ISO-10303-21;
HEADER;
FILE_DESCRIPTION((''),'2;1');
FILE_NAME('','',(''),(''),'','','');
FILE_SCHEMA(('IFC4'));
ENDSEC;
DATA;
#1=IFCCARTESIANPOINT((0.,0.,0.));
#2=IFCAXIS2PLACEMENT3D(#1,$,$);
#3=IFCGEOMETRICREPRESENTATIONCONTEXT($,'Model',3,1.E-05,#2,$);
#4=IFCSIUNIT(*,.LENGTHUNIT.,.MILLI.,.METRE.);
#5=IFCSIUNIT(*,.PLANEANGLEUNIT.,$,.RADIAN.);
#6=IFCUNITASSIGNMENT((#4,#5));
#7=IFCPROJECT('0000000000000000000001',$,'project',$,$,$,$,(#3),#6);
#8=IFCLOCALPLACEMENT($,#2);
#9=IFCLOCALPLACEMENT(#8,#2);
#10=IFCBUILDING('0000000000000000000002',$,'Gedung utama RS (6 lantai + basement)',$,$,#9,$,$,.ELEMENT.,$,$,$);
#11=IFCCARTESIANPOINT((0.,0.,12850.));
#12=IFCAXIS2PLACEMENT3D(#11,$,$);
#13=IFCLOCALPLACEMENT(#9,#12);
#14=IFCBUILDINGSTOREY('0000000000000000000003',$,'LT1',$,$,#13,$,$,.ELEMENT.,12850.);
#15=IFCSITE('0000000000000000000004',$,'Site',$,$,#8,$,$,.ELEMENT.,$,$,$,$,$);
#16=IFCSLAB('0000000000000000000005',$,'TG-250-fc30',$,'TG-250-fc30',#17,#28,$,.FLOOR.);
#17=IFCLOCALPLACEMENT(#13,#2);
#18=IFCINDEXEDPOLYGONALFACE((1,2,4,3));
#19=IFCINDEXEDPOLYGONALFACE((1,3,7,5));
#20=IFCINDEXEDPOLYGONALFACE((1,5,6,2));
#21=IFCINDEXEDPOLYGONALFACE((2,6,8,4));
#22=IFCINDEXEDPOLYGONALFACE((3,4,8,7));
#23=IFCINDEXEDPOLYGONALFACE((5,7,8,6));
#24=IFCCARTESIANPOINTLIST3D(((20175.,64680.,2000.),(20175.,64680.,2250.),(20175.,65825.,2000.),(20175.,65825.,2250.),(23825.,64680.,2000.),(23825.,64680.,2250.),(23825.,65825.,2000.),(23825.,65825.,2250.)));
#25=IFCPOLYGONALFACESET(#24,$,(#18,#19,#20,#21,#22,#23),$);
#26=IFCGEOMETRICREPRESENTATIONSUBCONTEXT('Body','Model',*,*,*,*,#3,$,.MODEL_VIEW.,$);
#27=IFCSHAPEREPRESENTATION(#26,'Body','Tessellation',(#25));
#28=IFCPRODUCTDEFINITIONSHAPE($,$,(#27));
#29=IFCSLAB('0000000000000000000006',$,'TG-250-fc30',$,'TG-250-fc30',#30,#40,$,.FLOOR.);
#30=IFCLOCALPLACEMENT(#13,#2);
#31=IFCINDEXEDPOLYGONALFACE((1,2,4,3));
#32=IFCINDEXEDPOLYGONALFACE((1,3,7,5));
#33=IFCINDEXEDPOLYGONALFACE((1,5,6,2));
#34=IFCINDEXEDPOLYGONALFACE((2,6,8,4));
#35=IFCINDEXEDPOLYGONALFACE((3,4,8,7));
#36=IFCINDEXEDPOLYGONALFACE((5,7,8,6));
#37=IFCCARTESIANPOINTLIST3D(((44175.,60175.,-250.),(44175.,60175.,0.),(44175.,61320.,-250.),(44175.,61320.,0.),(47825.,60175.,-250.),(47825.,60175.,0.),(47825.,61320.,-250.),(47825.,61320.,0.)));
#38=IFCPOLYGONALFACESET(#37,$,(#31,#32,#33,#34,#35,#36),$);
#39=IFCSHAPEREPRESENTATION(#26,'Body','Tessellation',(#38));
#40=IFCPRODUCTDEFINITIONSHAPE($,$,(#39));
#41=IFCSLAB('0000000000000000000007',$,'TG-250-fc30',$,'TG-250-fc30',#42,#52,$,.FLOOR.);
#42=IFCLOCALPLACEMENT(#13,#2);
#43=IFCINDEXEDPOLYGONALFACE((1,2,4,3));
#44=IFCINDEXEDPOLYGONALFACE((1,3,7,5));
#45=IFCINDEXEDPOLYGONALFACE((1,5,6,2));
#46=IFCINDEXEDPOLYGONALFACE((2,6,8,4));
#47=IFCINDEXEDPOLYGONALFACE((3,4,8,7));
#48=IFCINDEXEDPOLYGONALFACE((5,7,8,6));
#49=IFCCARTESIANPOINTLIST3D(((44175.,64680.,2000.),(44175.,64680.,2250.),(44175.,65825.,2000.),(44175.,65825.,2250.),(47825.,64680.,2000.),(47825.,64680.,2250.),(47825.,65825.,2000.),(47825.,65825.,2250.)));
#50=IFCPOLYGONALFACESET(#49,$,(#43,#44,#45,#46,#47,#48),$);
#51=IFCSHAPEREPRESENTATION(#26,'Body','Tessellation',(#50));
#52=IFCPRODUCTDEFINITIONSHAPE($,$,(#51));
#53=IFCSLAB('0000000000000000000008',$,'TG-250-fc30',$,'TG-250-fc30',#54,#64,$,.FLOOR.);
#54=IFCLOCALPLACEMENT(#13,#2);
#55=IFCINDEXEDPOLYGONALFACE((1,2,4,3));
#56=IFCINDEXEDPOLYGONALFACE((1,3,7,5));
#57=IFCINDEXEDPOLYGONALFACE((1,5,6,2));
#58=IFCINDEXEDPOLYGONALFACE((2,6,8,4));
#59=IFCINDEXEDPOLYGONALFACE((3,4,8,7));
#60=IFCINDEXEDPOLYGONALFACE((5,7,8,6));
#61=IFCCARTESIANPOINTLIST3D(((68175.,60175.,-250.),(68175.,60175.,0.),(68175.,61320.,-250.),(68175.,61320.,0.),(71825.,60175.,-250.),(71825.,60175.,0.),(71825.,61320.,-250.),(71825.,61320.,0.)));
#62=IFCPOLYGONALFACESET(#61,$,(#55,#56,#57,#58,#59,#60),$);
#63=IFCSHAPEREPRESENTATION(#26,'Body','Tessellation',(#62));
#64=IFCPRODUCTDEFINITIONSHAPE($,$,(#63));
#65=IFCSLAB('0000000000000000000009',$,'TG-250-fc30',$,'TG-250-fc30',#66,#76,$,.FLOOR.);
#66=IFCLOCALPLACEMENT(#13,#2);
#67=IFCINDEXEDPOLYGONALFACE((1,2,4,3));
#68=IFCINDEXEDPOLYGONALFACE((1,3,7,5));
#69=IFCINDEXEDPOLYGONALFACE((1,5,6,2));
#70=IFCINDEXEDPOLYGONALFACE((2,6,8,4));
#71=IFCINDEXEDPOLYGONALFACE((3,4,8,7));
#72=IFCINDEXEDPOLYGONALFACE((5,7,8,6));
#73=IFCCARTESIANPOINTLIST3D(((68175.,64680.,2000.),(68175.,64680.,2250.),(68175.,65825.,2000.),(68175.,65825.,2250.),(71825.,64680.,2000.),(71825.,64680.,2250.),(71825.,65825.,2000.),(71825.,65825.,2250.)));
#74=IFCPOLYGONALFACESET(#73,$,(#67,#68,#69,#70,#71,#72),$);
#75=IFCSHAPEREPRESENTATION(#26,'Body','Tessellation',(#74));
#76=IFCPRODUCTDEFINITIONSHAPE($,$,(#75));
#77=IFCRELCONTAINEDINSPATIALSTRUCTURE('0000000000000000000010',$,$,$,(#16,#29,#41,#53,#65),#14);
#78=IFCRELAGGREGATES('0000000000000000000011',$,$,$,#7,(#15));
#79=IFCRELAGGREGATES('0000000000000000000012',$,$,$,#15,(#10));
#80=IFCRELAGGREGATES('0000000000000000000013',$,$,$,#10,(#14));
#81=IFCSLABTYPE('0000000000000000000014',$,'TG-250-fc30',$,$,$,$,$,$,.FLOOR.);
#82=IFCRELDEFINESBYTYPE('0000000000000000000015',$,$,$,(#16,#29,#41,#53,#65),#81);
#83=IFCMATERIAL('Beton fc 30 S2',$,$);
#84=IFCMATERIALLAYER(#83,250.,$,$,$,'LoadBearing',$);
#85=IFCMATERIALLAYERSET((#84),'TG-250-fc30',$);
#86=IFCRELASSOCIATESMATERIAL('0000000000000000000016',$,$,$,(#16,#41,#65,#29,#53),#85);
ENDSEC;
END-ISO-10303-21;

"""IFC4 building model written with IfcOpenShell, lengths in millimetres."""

from ifc_helpers import new_model, si_unit, frame, origin, place, context, subcontext, project, spatial, polyline, outline, extrude, material, layer, layer_set, layer_usage, type_object, element, save


model = new_model("IFC4")

# Units and contexts
model_context = context("Model", 3, precision=1e-05, world=origin())
body_context = subcontext(model_context, "Body", "Model", "MODEL_VIEW")
ifc_project = project(units=[si_unit("LENGTHUNIT", "METRE", prefix="MILLI"), si_unit("PLANEANGLEUNIT", "RADIAN")], contexts=[model_context])

# Site, building, storey
site_placement = place(None, origin())
site = spatial("IfcSite", under=ifc_project, at=site_placement, Name="Site", CompositionType="ELEMENT")
building_placement = place(site_placement, origin())
building = spatial("IfcBuilding", under=site, at=building_placement, Name="Gedung utama RS (6 lantai + basement)", CompositionType="ELEMENT")
storey_placement = place(building_placement, frame((0.0, 0.0, 12850.0)))
storey = spatial("IfcBuildingStorey", under=building, at=storey_placement, Name="LT1", CompositionType="ELEMENT", Elevation=12850.0)

# Slabs
ifc_material_1 = material(Name="Beton fc 30 S2")
ifc_layer_1 = layer(ifc_material_1, 250.0, Category="LoadBearing")
ifc_layer_set_1 = layer_set([ifc_layer_1], Name="TG-250-fc30")
ifc_layer_usage_1 = layer_usage(ifc_layer_set_1, "AXIS3", "NEGATIVE", 0.0)
slab_type_1 = type_object("IfcSlabType", Name="TG-250-fc30", PredefinedType="FLOOR")
ifc_layer_usage_2 = layer_usage(ifc_layer_set_1, "AXIS3", "NEGATIVE", 2250.0)
slab_1_placement = place(storey_placement, origin())
element("IfcSlab", 1, at=slab_1_placement, inside=storey, type_object=slab_type_1, material=ifc_layer_usage_2, Name="TG-250-fc30", ObjectType="TG-250-fc30", PredefinedType="FLOOR", context=body_context, shape_type="SweptSolid", body=[
    extrude(outline(polyline([(23825.0, 64680.0), (23825.0, 65825.0), (20175.0, 65825.0), (20175.0, 64680.0), (23825.0, 64680.0)])), frame((0.0, 0.0, 2000.0)), (0.0, 0.0, 1.0), 250.0),
])
slab_2_placement = place(storey_placement, origin())
element("IfcSlab", 2, at=slab_2_placement, inside=storey, type_object=slab_type_1, material=ifc_layer_usage_1, Name="TG-250-fc30", ObjectType="TG-250-fc30", PredefinedType="FLOOR", context=body_context, shape_type="SweptSolid", body=[
    extrude(outline(polyline([(47825.0, 60175.0), (47825.0, 61320.0), (44175.0, 61320.0), (44175.0, 60175.0), (47825.0, 60175.0)])), frame((0.0, 0.0, -250.0)), (0.0, 0.0, 1.0), 250.0),
])
slab_3_placement = place(storey_placement, origin())
element("IfcSlab", 3, at=slab_3_placement, inside=storey, type_object=slab_type_1, material=ifc_layer_usage_2, Name="TG-250-fc30", ObjectType="TG-250-fc30", PredefinedType="FLOOR", context=body_context, shape_type="SweptSolid", body=[
    extrude(outline(polyline([(47825.0, 64680.0), (47825.0, 65825.0), (44175.0, 65825.0), (44175.0, 64680.0), (47825.0, 64680.0)])), frame((0.0, 0.0, 2000.0)), (0.0, 0.0, 1.0), 250.0),
])
slab_4_placement = place(storey_placement, origin())
element("IfcSlab", 4, at=slab_4_placement, inside=storey, type_object=slab_type_1, material=ifc_layer_usage_1, Name="TG-250-fc30", ObjectType="TG-250-fc30", PredefinedType="FLOOR", context=body_context, shape_type="SweptSolid", body=[
    extrude(outline(polyline([(71825.0, 60175.0), (71825.0, 61320.0), (68175.0, 61320.0), (68175.0, 60175.0), (71825.0, 60175.0)])), frame((0.0, 0.0, -250.0)), (0.0, 0.0, 1.0), 250.0),
])
slab_5_placement = place(storey_placement, origin())
element("IfcSlab", 5, at=slab_5_placement, inside=storey, type_object=slab_type_1, material=ifc_layer_usage_2, Name="TG-250-fc30", ObjectType="TG-250-fc30", PredefinedType="FLOOR", context=body_context, shape_type="SweptSolid", body=[
    extrude(outline(polyline([(71825.0, 64680.0), (71825.0, 65825.0), (68175.0, 65825.0), (68175.0, 64680.0), (71825.0, 64680.0)])), frame((0.0, 0.0, 2000.0)), (0.0, 0.0, 1.0), 250.0),
])

save(model, "model.ifc")
